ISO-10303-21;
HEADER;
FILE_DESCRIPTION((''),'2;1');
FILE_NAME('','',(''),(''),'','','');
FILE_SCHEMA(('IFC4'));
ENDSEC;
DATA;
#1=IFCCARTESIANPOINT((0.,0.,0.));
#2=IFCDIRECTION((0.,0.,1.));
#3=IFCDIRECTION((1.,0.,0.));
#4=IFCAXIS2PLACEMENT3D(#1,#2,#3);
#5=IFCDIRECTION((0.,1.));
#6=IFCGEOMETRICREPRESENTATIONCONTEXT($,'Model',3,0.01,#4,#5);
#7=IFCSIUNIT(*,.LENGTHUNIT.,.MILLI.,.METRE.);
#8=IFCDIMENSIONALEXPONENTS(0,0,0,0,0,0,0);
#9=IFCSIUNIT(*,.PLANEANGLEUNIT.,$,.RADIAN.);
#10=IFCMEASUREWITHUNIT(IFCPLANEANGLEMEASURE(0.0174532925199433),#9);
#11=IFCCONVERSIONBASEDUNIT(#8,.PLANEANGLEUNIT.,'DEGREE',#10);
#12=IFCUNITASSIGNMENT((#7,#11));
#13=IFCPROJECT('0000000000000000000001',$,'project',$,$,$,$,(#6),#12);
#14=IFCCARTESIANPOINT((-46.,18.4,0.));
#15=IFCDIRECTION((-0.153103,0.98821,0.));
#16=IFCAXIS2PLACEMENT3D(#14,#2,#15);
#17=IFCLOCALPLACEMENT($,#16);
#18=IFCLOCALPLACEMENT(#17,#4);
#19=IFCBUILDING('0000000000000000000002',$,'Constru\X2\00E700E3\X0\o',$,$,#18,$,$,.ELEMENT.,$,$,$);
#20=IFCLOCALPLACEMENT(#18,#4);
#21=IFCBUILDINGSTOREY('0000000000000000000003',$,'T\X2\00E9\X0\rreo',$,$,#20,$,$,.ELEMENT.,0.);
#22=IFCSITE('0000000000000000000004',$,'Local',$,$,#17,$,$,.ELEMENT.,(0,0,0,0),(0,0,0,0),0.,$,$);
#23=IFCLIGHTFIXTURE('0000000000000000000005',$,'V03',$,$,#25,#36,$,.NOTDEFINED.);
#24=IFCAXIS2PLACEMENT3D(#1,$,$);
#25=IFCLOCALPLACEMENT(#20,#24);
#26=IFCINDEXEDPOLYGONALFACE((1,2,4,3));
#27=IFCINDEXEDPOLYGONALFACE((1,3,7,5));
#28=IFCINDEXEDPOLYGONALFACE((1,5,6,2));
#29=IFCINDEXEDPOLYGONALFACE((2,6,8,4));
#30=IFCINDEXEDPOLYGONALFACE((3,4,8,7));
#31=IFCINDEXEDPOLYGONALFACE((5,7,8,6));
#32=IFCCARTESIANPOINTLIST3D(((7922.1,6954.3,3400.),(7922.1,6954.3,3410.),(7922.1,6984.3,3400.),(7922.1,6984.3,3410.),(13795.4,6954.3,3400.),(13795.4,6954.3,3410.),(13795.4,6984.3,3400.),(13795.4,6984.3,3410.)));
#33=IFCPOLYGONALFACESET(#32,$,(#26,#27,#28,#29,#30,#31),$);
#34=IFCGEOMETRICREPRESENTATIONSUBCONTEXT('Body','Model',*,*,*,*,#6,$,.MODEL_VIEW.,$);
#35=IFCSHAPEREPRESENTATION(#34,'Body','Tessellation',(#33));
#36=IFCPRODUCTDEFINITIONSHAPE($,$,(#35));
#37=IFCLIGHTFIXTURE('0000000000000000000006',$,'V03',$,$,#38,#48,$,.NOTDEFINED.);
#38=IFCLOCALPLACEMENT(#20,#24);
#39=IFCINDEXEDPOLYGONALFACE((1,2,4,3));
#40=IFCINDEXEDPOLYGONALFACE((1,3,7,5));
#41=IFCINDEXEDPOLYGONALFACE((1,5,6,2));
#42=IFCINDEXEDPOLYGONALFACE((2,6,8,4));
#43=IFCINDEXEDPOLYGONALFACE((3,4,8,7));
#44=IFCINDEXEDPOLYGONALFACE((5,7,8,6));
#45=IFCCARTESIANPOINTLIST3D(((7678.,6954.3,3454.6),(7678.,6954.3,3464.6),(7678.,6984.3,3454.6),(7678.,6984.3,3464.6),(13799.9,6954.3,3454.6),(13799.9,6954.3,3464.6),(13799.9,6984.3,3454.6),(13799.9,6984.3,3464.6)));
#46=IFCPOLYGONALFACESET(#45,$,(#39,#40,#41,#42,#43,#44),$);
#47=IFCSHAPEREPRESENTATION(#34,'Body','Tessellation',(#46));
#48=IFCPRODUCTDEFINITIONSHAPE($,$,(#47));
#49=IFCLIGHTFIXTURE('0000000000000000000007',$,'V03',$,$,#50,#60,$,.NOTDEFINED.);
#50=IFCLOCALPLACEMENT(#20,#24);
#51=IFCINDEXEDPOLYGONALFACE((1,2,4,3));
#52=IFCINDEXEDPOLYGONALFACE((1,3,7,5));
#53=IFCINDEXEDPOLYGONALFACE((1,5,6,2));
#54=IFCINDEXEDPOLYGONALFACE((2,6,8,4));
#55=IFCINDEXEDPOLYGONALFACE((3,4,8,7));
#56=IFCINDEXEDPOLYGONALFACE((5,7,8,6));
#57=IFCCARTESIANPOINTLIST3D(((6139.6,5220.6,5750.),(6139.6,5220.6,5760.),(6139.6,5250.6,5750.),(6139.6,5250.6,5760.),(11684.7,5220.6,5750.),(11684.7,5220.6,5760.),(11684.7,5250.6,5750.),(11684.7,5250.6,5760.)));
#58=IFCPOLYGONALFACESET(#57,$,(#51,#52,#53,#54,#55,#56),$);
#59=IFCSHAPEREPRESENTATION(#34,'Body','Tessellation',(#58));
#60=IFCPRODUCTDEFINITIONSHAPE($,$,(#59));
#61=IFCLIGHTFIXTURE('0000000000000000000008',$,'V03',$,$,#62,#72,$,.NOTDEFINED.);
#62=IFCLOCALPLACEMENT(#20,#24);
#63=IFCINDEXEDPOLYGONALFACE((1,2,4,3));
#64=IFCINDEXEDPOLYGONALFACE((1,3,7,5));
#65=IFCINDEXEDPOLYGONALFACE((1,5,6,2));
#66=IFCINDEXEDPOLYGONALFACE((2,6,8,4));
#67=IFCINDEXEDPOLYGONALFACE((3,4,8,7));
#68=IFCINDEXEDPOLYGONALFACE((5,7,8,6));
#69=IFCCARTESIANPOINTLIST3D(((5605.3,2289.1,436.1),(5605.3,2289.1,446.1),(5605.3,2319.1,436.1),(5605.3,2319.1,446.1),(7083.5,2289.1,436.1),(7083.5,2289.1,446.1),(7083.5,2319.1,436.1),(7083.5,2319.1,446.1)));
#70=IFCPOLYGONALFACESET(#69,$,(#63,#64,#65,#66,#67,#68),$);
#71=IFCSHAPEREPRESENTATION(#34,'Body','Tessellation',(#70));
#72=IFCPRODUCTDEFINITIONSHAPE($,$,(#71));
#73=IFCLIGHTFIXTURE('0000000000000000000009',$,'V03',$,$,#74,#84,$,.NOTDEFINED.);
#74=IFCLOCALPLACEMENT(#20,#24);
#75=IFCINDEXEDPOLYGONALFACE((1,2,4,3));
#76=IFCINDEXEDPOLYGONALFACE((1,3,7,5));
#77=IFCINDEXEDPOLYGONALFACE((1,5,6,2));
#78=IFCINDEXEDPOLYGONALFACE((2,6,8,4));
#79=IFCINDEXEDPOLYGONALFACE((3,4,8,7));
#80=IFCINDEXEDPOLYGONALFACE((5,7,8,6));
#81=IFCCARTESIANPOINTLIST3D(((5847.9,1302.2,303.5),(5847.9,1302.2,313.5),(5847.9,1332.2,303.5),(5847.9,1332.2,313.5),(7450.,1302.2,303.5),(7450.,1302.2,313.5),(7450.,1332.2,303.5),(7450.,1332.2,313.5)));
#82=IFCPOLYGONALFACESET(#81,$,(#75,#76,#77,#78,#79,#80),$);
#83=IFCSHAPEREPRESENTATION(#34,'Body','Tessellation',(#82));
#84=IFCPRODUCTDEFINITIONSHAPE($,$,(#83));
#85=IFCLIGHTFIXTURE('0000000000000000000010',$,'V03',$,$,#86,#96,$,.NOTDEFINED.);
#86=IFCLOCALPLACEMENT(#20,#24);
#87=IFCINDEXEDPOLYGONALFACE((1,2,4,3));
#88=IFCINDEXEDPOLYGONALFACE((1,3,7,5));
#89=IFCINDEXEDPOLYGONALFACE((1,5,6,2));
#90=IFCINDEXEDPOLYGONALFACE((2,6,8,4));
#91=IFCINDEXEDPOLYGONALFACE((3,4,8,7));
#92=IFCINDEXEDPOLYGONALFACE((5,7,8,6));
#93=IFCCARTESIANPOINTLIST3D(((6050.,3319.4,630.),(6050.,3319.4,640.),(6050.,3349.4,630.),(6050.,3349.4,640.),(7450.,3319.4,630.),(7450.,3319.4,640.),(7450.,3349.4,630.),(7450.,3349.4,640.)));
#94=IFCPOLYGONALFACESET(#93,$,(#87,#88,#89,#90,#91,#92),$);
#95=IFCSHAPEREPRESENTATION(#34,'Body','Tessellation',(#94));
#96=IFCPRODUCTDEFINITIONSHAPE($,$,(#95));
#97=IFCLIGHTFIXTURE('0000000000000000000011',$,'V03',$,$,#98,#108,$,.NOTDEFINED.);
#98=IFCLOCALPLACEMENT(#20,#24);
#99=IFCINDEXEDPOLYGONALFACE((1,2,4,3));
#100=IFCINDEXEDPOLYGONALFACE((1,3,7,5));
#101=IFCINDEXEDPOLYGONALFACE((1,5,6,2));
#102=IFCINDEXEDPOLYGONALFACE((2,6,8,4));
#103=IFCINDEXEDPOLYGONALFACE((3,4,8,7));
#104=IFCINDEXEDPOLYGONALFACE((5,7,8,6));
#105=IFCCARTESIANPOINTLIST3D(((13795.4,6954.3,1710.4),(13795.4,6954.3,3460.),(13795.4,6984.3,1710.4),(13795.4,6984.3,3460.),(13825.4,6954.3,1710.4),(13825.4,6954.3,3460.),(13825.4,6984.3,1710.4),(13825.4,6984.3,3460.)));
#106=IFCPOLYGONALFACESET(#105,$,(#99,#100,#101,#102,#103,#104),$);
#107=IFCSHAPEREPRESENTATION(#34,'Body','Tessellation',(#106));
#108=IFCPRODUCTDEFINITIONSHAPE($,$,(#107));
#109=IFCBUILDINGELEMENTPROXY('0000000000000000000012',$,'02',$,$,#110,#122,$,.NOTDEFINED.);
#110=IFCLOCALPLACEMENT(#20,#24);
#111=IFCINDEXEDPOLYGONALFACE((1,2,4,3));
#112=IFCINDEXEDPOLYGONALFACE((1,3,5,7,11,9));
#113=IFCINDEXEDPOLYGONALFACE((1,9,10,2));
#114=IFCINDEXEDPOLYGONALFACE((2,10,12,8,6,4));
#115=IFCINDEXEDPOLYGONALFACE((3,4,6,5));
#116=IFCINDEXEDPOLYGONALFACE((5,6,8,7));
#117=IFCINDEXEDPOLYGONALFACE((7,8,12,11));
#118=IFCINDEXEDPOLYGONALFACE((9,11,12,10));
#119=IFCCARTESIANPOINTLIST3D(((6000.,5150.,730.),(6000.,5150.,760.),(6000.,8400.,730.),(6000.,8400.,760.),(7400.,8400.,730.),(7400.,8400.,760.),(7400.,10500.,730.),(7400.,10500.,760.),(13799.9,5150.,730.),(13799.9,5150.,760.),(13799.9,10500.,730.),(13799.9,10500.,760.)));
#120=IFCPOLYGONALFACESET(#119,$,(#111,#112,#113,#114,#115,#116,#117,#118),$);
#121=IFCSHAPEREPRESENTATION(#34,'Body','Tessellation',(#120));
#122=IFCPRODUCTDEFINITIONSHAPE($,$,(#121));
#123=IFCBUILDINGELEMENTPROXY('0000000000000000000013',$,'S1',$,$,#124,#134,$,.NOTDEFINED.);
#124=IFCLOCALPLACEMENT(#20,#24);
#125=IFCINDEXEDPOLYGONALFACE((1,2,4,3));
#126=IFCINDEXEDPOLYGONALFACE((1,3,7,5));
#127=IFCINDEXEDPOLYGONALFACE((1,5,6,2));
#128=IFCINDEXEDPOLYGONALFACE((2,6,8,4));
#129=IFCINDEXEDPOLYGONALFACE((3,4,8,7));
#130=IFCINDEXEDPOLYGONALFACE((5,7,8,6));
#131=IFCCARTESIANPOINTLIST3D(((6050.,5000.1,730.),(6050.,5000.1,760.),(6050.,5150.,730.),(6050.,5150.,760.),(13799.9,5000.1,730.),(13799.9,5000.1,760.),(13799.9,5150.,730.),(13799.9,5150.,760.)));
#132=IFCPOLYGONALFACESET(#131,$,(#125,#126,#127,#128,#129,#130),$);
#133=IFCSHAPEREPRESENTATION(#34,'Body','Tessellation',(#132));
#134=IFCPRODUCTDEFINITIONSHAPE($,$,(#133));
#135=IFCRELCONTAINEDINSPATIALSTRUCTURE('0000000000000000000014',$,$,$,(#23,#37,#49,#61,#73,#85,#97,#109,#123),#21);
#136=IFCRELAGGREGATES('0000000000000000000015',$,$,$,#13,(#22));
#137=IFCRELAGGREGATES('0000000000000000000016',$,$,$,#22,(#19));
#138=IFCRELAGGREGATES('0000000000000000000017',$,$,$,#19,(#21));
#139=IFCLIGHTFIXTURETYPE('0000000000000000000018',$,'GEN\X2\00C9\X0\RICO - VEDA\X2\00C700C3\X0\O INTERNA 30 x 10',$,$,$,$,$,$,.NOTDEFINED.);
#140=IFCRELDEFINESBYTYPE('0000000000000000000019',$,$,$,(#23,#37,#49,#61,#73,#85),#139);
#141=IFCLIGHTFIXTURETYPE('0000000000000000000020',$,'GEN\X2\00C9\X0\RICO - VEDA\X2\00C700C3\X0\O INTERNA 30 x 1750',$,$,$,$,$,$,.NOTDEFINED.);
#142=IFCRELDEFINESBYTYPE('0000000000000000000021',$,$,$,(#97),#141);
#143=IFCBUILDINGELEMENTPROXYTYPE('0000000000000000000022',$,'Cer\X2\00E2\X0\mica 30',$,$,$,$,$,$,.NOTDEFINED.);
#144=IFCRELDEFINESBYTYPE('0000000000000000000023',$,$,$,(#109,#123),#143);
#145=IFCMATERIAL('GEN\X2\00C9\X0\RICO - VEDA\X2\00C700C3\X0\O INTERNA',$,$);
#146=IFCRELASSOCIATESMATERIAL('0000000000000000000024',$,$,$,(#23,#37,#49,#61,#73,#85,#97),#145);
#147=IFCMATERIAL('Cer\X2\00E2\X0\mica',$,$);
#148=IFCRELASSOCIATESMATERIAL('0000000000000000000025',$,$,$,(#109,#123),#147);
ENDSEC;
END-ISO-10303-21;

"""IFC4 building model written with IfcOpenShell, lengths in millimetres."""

from ifc_helpers import new_model, entity, si_unit, converted_unit, direction, frame, frame_2d, origin_with_axes, place, context, subcontext, project, spatial, line, indexed_curve, rectangle, outline, extrude, material, type_object, element, save


model = new_model("IFC4")

# Units and contexts
model_context = context("Model", 3, precision=0.01, world=origin_with_axes(), true_north=direction((0.0, 1.0)))
body_context = subcontext(model_context, "Body", "Model", "MODEL_VIEW")
ifc_project = project(units=[si_unit("LENGTHUNIT", "METRE", prefix="MILLI"), converted_unit("PLANEANGLEUNIT", "DEGREE", entity("IfcPlaneAngleMeasure", 0.0174532925199433), si_unit("PLANEANGLEUNIT", "RADIAN"), dimensions=[0, 0, 0, 0, 0, 0, 0])], contexts=[model_context])

# Site, building, storey
site_placement = place(None, frame((-46.0, 18.4, 0.0), z_axis=(0.0, 0.0, 1.0), x_axis=(-0.153103, 0.98821, 0.0)))
site = spatial("IfcSite", under=ifc_project, at=site_placement, Name="Local", CompositionType="ELEMENT", RefLatitude=(0, 0, 0, 0), RefLongitude=(0, 0, 0, 0), RefElevation=0.0)
building_placement = place(site_placement, origin_with_axes())
building = spatial("IfcBuilding", under=site, at=building_placement, Name="Construção", CompositionType="ELEMENT")
storey_placement = place(building_placement, origin_with_axes())
storey = spatial("IfcBuildingStorey", under=building, at=storey_placement, Name="Térreo", CompositionType="ELEMENT", Elevation=0.0)

# Light fixtures
ifc_material_1 = material(Name="GENÉRICO - VEDAÇÃO INTERNA")
light_fixture_type_1 = type_object("IfcLightFixtureType", Name="GENÉRICO - VEDAÇÃO INTERNA 30 x 10", PredefinedType="NOTDEFINED")
light_fixture_1_placement = place(storey_placement, frame((7922.1, 6984.3, 3410.0), z_axis=(0.0, 0.0, 1.0), x_axis=(0.0, -1.0, 0.0)))
element("IfcLightFixture", 1, at=light_fixture_1_placement, inside=storey, type_object=light_fixture_type_1, material=ifc_material_1, Name="V03", PredefinedType="NOTDEFINED", context=body_context, shape_type="SweptSolid", body=[
    extrude(rectangle(XDim=10.0, YDim=30.0, at=frame_2d((-5.0, 15.0), x_axis=(1.0, 0.0))), frame((0.0, 0.0, 0.0), z_axis=(0.0, 1.0, 0.0), x_axis=(0.0, 0.0, 1.0)), (0.0, 0.0, 1.0), 5873.4),
])
light_fixture_2_placement = place(storey_placement, frame((7678.0, 6984.3, 3464.6), z_axis=(0.0, 0.0, 1.0), x_axis=(0.000002, -1.0, 0.0)))
element("IfcLightFixture", 2, at=light_fixture_2_placement, inside=storey, type_object=light_fixture_type_1, material=ifc_material_1, Name="V03", PredefinedType="NOTDEFINED", context=body_context, shape_type="SweptSolid", body=[
    extrude(rectangle(XDim=10.0, YDim=30.0, at=frame_2d((-5.0, 15.0), x_axis=(1.0, 0.0))), frame((0.0, 0.0, 0.0), z_axis=(0.0, 1.0, 0.0), x_axis=(0.0, 0.0, 1.0)), (0.0, 0.0, 1.0), 6122.0),
])
light_fixture_3_placement = place(storey_placement, frame((6139.6, 5250.6, 5760.0), z_axis=(0.0, 0.0, 1.0), x_axis=(0.0, -1.0, 0.0)))
element("IfcLightFixture", 3, at=light_fixture_3_placement, inside=storey, type_object=light_fixture_type_1, material=ifc_material_1, Name="V03", PredefinedType="NOTDEFINED", context=body_context, shape_type="SweptSolid", body=[
    extrude(rectangle(XDim=10.0, YDim=30.0, at=frame_2d((-5.0, 15.0), x_axis=(1.0, 0.0))), frame((0.0, 0.0, 0.0), z_axis=(0.0, 1.0, 0.0), x_axis=(0.0, 0.0, 1.0)), (0.0, 0.0, 1.0), 5545.0),
])
light_fixture_4_placement = place(storey_placement, frame((5605.3, 2319.1, 446.1), z_axis=(0.0, 0.0, 1.0), x_axis=(0.0, -1.0, 0.0)))
element("IfcLightFixture", 4, at=light_fixture_4_placement, inside=storey, type_object=light_fixture_type_1, material=ifc_material_1, Name="V03", PredefinedType="NOTDEFINED", context=body_context, shape_type="SweptSolid", body=[
    extrude(rectangle(XDim=10.0, YDim=30.0, at=frame_2d((-5.0, 15.0), x_axis=(1.0, 0.0))), frame((0.0, 0.0, 0.0), z_axis=(0.0, 1.0, 0.0), x_axis=(0.0, 0.0, 1.0)), (0.0, 0.0, 1.0), 1478.2),
])
light_fixture_5_placement = place(storey_placement, frame((5847.9, 1332.2, 313.5), z_axis=(0.0, 0.0, 1.0), x_axis=(0.0, -1.0, 0.0)))
element("IfcLightFixture", 5, at=light_fixture_5_placement, inside=storey, type_object=light_fixture_type_1, material=ifc_material_1, Name="V03", PredefinedType="NOTDEFINED", context=body_context, shape_type="SweptSolid", body=[
    extrude(rectangle(XDim=10.0, YDim=30.0, at=frame_2d((-5.0, 15.0), x_axis=(1.0, 0.0))), frame((0.0, 0.0, 0.0), z_axis=(0.0, 1.0, 0.0), x_axis=(0.0, 0.0, 1.0)), (0.0, 0.0, 1.0), 1602.1),
])
light_fixture_6_placement = place(storey_placement, frame((6050.0, 3349.4, 640.0), z_axis=(0.0, 0.0, 1.0), x_axis=(0.0, -1.0, 0.0)))
element("IfcLightFixture", 6, at=light_fixture_6_placement, inside=storey, type_object=light_fixture_type_1, material=ifc_material_1, Name="V03", PredefinedType="NOTDEFINED", context=body_context, shape_type="SweptSolid", body=[
    extrude(rectangle(XDim=10.0, YDim=30.0, at=frame_2d((-5.0, 15.0), x_axis=(1.0, 0.0))), frame((0.0, 0.0, 0.0), z_axis=(0.0, 1.0, 0.0), x_axis=(0.0, 0.0, 1.0)), (0.0, 0.0, 1.0), 1400.0),
])
light_fixture_type_2 = type_object("IfcLightFixtureType", Name="GENÉRICO - VEDAÇÃO INTERNA 30 x 1750", PredefinedType="NOTDEFINED")
light_fixture_7_placement = place(storey_placement, frame((13795.4, 6984.3, 3460.0), z_axis=(0.0, 0.0, 1.0), x_axis=(0.000002, -1.0, 0.0)))
element("IfcLightFixture", 7, at=light_fixture_7_placement, inside=storey, type_object=light_fixture_type_2, material=ifc_material_1, Name="V03", PredefinedType="NOTDEFINED", context=body_context, shape_type="SweptSolid", body=[
    extrude(rectangle(XDim=1749.6, YDim=30.0, at=frame_2d((-874.8, 15.0), x_axis=(1.0, 0.0))), frame((0.0, 0.0, 0.0), z_axis=(0.0, 1.0, 0.0), x_axis=(0.0, 0.0, 1.0)), (0.0, 0.0, 1.0), 30.0),
])

# Building element proxies
ifc_material_2 = material(Name="Cerâmica")
building_element_proxy_type = type_object("IfcBuildingElementProxyType", Name="Cerâmica 30", PredefinedType="NOTDEFINED")
proxy_1_placement = place(storey_placement, frame((6000.0, 8400.0, 760.0), z_axis=(0.0, 0.0, 1.0), x_axis=(1.0, 0.0, 0.0)))
element("IfcBuildingElementProxy", 8, at=proxy_1_placement, inside=storey, type_object=building_element_proxy_type, material=ifc_material_2, Name="02", PredefinedType="NOTDEFINED", context=body_context, shape_type="SweptSolid", body=[
    extrude(outline(indexed_curve([(0.0, 0.0), (0.0, -3250.0), (7799.9, -3250.0), (7799.9, 2100.0), (1400.0, 2100.0), (1400.0, 0.0)], segments=[line(1, 2, 3, 4, 5, 6, 1)])), frame((0.0, 0.0, -30.0), z_axis=(0.0, 0.0, 1.0), x_axis=(1.0, 0.0, 0.0)), (0.0, 0.0, 1.0), 30.0),
])
proxy_2_placement = place(storey_placement, frame((6050.0, 5150.0, 760.0), z_axis=(0.0, 0.0, 1.0), x_axis=(1.0, 0.0, 0.0)))
element("IfcBuildingElementProxy", 9, at=proxy_2_placement, inside=storey, type_object=building_element_proxy_type, material=ifc_material_2, Name="S1", PredefinedType="NOTDEFINED", context=body_context, shape_type="SweptSolid", body=[
    extrude(outline(indexed_curve([(0.0, 0.0), (0.0, -150.0), (7749.9, -150.0), (7749.9, 0.0)], segments=[line(1, 2, 3, 4, 1)])), frame((0.0, 0.0, -30.0), z_axis=(0.0, 0.0, 1.0), x_axis=(1.0, 0.0, 0.0)), (0.0, 0.0, 1.0), 30.0),
])

save(model, "model.ifc")
